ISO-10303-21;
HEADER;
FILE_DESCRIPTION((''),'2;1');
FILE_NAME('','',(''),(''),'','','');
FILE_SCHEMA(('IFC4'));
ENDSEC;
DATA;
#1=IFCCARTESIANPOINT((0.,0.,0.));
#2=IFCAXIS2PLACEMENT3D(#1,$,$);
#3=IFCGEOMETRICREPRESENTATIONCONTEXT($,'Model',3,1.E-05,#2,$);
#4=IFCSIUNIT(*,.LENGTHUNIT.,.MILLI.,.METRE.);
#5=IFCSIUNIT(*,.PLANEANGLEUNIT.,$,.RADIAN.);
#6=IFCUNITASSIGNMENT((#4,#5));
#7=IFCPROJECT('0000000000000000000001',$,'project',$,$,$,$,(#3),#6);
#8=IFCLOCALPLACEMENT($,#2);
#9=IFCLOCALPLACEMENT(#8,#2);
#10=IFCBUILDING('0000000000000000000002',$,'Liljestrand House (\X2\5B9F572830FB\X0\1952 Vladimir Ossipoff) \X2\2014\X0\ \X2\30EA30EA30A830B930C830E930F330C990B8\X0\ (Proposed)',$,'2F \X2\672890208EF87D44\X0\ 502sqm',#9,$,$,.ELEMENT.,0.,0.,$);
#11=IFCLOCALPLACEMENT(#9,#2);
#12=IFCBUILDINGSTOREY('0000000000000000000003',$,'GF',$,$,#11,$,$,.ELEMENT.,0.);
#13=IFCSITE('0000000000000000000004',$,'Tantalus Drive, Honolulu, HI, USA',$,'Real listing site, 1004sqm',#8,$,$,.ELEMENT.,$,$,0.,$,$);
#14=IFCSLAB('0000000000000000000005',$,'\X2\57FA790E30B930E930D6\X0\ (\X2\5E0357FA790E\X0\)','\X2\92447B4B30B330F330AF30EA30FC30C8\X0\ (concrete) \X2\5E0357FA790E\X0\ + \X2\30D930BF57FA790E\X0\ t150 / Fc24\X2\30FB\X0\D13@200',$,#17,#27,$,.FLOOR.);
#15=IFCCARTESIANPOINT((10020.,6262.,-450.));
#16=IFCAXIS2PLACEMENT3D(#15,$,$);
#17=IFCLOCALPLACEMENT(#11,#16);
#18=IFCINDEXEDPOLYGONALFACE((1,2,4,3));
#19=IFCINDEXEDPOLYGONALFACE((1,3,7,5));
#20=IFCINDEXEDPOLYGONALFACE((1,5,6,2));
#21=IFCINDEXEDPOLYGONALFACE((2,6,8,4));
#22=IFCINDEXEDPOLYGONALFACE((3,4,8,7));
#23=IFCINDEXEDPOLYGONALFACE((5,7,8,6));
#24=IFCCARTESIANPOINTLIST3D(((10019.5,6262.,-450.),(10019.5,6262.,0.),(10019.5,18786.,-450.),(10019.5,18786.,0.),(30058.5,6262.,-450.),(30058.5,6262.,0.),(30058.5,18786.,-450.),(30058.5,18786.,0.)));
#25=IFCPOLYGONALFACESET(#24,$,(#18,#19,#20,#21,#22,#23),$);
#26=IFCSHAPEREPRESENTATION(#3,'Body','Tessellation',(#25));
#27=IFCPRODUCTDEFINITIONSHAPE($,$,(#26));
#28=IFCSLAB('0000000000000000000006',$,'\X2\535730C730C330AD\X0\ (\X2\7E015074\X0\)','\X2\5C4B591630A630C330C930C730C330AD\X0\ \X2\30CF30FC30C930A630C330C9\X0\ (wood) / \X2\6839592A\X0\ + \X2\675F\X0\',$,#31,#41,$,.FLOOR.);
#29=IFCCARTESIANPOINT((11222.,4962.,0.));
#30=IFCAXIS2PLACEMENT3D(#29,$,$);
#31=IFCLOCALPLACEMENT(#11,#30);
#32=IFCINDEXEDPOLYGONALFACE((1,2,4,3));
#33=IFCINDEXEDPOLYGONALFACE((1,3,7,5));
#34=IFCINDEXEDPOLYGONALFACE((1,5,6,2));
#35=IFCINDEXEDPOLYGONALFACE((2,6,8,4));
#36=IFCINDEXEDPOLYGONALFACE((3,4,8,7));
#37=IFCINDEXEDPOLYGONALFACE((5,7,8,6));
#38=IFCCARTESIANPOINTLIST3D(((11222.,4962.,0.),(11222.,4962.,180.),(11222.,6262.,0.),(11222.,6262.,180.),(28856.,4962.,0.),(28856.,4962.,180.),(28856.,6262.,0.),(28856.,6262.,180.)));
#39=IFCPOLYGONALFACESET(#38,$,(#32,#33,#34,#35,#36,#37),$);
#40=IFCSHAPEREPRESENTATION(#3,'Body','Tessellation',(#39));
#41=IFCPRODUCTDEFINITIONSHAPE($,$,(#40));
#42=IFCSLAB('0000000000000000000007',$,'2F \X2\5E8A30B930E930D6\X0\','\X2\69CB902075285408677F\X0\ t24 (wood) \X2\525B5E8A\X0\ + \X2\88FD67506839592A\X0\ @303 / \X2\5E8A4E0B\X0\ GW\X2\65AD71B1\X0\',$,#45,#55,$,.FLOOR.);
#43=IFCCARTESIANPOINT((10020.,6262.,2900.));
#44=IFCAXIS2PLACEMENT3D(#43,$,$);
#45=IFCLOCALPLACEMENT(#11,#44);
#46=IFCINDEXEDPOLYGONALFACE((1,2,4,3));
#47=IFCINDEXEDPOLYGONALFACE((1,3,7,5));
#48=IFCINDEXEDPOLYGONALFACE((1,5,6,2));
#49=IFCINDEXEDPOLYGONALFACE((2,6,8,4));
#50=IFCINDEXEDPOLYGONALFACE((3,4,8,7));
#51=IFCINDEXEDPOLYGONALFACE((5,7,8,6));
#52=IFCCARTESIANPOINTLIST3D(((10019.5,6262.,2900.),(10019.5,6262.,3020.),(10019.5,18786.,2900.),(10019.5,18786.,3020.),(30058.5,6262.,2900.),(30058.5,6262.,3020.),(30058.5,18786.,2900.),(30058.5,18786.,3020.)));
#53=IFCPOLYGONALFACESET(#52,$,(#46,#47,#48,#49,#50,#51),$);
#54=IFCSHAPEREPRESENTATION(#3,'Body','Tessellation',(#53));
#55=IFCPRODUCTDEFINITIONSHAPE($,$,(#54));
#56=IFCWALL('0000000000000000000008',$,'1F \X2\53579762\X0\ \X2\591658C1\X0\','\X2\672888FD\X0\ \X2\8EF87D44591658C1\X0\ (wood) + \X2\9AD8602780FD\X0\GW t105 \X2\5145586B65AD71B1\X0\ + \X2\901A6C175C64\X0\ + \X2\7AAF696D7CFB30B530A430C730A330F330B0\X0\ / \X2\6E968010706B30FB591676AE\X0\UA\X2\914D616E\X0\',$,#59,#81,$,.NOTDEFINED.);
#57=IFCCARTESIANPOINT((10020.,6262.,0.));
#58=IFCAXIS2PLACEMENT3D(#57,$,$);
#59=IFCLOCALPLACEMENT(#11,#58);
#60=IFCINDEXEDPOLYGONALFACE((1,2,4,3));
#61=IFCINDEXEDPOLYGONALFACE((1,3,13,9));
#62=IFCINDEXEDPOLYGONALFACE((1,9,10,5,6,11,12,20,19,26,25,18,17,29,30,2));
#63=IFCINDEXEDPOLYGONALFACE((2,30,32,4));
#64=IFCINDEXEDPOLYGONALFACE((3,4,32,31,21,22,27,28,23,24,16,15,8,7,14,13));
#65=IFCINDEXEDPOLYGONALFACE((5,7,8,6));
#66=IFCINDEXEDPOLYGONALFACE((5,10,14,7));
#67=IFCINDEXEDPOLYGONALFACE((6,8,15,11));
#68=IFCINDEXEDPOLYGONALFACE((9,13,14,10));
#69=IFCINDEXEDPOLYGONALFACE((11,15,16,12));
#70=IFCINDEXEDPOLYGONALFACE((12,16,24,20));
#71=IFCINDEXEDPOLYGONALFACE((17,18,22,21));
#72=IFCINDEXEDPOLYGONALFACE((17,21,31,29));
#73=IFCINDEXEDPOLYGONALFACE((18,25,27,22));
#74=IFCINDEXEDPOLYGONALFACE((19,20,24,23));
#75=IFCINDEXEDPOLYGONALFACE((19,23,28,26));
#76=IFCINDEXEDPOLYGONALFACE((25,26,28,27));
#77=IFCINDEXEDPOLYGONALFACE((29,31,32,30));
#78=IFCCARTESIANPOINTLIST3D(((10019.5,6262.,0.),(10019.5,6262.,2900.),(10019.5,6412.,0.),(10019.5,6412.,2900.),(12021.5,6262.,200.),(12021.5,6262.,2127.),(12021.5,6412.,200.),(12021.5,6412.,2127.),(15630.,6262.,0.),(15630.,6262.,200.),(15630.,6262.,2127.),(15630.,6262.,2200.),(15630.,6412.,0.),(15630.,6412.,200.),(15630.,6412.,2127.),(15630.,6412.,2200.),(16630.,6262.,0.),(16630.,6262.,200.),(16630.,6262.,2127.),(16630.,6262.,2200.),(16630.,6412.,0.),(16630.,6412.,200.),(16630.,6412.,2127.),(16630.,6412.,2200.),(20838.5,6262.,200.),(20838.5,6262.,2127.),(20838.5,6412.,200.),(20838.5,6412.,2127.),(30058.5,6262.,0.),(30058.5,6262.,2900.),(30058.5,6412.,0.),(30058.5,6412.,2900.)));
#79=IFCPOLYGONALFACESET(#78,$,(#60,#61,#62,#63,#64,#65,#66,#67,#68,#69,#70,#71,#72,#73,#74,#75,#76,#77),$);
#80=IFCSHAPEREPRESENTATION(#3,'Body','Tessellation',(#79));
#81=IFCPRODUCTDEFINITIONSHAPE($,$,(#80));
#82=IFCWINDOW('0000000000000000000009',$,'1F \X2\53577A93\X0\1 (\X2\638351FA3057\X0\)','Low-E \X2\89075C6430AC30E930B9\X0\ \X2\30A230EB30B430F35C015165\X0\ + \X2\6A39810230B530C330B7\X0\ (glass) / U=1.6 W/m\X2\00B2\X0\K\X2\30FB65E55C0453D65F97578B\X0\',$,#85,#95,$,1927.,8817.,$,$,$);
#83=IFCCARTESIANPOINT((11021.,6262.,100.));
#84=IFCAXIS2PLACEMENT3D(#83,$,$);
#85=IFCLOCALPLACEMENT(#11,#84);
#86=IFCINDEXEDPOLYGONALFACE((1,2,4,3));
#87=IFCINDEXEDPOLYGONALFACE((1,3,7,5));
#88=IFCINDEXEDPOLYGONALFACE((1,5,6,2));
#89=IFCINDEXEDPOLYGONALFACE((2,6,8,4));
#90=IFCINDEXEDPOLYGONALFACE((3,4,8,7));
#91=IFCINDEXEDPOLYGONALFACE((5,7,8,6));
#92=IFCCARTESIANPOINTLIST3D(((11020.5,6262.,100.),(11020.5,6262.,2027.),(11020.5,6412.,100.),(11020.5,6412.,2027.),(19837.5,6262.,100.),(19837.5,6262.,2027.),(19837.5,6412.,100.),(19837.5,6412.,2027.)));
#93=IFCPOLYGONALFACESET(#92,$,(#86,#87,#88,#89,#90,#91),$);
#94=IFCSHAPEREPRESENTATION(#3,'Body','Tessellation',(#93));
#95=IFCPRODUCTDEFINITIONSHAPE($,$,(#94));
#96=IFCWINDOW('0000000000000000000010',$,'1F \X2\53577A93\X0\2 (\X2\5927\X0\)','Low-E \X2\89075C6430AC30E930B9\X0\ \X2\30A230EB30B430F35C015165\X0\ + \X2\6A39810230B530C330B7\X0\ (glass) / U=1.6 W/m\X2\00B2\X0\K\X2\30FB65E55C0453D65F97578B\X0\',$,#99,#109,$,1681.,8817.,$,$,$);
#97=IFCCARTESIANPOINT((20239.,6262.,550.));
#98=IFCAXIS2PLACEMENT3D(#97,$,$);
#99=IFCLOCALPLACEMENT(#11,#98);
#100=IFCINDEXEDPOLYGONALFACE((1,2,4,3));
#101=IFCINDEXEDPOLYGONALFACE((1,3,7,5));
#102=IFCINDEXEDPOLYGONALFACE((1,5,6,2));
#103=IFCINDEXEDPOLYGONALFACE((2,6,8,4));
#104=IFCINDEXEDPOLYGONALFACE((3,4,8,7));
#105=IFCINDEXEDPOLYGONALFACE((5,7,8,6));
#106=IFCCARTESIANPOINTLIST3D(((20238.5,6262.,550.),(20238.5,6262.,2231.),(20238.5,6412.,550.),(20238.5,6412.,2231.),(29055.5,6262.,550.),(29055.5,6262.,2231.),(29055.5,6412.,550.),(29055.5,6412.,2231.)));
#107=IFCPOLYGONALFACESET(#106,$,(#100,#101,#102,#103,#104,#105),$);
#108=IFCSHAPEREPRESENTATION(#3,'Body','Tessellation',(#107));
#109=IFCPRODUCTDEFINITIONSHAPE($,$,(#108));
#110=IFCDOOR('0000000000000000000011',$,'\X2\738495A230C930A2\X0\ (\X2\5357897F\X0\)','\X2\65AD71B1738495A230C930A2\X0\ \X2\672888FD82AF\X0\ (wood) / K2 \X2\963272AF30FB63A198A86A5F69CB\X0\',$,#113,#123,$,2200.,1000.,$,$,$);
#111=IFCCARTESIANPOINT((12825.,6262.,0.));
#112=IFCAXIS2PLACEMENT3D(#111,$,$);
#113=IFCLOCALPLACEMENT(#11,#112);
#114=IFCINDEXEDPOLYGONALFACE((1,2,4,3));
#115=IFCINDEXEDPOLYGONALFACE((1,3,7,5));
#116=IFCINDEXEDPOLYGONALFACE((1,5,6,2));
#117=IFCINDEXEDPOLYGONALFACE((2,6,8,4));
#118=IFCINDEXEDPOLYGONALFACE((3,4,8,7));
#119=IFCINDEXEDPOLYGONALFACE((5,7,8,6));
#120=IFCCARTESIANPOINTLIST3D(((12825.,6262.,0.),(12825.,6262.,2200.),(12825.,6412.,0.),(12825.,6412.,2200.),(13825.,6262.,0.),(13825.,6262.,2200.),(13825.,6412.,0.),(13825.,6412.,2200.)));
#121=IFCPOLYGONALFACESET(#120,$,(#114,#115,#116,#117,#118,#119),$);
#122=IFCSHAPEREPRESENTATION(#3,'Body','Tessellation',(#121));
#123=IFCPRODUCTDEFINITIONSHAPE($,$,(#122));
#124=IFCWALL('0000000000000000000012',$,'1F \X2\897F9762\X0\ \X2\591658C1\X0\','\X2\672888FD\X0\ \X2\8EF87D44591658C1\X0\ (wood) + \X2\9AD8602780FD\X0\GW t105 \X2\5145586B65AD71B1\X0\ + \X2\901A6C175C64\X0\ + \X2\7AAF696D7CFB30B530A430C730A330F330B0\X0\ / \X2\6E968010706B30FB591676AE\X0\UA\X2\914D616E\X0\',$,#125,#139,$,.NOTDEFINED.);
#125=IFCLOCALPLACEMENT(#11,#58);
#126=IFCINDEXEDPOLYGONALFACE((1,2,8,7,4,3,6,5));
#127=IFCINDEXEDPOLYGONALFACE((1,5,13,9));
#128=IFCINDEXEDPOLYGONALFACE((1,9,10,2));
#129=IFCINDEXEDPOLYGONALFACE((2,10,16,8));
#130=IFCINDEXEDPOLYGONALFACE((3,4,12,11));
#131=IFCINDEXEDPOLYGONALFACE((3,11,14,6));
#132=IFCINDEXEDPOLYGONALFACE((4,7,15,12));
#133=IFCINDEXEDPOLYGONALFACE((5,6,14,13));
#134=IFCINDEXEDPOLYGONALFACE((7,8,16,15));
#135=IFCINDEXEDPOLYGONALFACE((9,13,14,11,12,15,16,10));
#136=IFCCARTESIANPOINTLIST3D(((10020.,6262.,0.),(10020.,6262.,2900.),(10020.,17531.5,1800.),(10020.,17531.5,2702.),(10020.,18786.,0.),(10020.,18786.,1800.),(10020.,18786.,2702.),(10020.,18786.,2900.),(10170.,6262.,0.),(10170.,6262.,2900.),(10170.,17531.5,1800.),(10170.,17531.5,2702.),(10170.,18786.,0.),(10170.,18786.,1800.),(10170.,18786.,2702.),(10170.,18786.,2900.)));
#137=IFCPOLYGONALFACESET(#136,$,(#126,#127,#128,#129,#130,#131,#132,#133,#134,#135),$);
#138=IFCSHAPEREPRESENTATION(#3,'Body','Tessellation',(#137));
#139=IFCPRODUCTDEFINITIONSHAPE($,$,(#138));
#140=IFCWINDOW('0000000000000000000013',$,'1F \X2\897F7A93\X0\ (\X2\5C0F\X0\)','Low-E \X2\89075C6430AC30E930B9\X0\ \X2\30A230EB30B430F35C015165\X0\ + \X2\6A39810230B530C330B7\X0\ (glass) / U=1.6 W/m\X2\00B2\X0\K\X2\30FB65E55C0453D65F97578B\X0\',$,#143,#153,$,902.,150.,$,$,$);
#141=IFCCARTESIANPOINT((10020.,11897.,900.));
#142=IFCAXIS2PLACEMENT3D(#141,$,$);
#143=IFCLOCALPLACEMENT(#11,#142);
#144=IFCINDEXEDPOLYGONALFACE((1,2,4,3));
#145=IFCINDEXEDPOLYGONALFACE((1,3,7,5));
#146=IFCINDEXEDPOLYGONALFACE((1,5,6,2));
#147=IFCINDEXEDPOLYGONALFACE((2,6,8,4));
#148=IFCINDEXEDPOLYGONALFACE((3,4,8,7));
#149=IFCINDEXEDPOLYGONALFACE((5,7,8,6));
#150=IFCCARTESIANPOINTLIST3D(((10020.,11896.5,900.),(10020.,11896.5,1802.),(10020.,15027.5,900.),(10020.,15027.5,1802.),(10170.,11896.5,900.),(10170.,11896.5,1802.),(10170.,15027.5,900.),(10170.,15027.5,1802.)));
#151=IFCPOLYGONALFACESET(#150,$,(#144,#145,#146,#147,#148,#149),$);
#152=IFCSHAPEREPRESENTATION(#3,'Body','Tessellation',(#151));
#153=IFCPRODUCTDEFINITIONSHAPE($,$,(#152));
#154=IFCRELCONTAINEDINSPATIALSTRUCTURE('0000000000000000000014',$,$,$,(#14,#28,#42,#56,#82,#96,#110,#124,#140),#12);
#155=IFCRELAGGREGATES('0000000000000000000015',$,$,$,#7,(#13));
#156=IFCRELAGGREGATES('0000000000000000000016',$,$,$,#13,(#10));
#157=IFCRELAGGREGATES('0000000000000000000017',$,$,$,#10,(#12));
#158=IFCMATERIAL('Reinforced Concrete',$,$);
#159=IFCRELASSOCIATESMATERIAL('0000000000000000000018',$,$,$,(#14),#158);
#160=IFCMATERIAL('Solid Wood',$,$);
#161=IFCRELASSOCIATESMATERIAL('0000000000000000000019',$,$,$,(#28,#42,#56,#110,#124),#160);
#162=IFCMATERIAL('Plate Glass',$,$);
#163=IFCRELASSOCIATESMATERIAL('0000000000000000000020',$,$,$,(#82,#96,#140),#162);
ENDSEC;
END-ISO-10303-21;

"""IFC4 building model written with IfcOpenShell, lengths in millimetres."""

from ifc_helpers import new_model, si_unit, frame, frame_2d, origin, place, context, project, spatial, rectangle, extrude, material, element, fill, save


model = new_model("IFC4")

# Units and contexts
model_context = context("Model", 3, precision=1e-05, world=origin())
ifc_project = project(units=[si_unit("LENGTHUNIT", "METRE", prefix="MILLI"), si_unit("PLANEANGLEUNIT", "RADIAN")], contexts=[model_context])

# Site, building, storey
site_placement = place(None, origin())
site = spatial("IfcSite", under=ifc_project, at=site_placement, Name="Tantalus Drive, Honolulu, HI, USA", ObjectType="Real listing site, 1004sqm", CompositionType="ELEMENT", RefElevation=0.0)
building_placement = place(site_placement, origin())
building = spatial("IfcBuilding", under=site, at=building_placement, Name="Liljestrand House (実在・1952 Vladimir Ossipoff) — リリエストランド邸 (Proposed)", ObjectType="2F 木造軸組 502sqm", CompositionType="ELEMENT", ElevationOfRefHeight=0.0, ElevationOfTerrain=0.0)
storey_placement = place(building_placement, origin())
storey = spatial("IfcBuildingStorey", under=building, at=storey_placement, Name="GF", CompositionType="ELEMENT", Elevation=0.0)

# Slabs
ifc_material_1 = material(Name="Reinforced Concrete")
slab_1_placement = place(storey_placement, frame((10020.0, 6262.0, -450.0)))
element("IfcSlab", 1, at=slab_1_placement, inside=storey, material=ifc_material_1, Name="基礎スラブ (布基礎)", Description="鉄筋コンクリート (concrete) 布基礎 + ベタ基礎 t150 / Fc24・D13@200", PredefinedType="FLOOR", context=model_context, shape_type="SweptSolid", body=[
    extrude(rectangle(XDim=20039.0, YDim=12524.0, at=frame_2d((10019.0, 6262.0))), frame((10020.0, 6262.0, -450.0)), (0.0, 0.0, 1.0), 450.0),
])
ifc_material_2 = material(Name="Solid Wood")
slab_2_placement = place(storey_placement, frame((11222.0, 4962.0, 0.0)))
element("IfcSlab", 2, at=slab_2_placement, inside=storey, material=ifc_material_2, Name="南デッキ (縁側)", Description="屋外ウッドデッキ ハードウッド (wood) / 根太 + 束", PredefinedType="FLOOR", context=model_context, shape_type="SweptSolid", body=[
    extrude(rectangle(XDim=17634.0, YDim=1300.0, at=frame_2d((8817.0, 650.0))), frame((11222.0, 4962.0, 0.0)), (0.0, 0.0, 1.0), 180.0),
])
slab_3_placement = place(storey_placement, frame((10020.0, 6262.0, 2900.0)))
element("IfcSlab", 3, at=slab_3_placement, inside=storey, material=ifc_material_2, Name="2F 床スラブ", Description="構造用合板 t24 (wood) 剛床 + 製材根太 @303 / 床下 GW断熱", PredefinedType="FLOOR", context=model_context, shape_type="SweptSolid", body=[
    extrude(rectangle(XDim=20039.0, YDim=12524.0, at=frame_2d((10019.0, 6262.0))), frame((10020.0, 6262.0, 2900.0)), (0.0, 0.0, 1.0), 120.0),
])

# Wall, openings, windows, door
wall_1_placement = place(storey_placement, frame((10020.0, 6262.0, 0.0)))
wall_1 = element("IfcWall", 4, at=wall_1_placement, inside=storey, material=ifc_material_2, Name="1F 南面 外壁", Description="木製 軸組外壁 (wood) + 高性能GW t105 充填断熱 + 通気層 + 窯業系サイディング / 準耐火・外皮UA配慮", PredefinedType="NOTDEFINED", context=model_context, shape_type="SweptSolid", body=[
    extrude(rectangle(XDim=20039.0, YDim=150.0, at=frame_2d((10019.0, 75.0))), frame((10020.0, 6262.0, 0.0)), (0.0, 0.0, 1.0), 2900.0),
])
opening_1_placement = place(storey_placement, frame((11021.0, 6262.0, 100.0)))
opening_1 = element("IfcOpeningElement", 5, at=opening_1_placement, cuts=wall_1, PredefinedType="NOTDEFINED", context=model_context, shape_type="SweptSolid", body=[
    extrude(rectangle(XDim=8817.0, YDim=150.0, at=frame_2d((4408.0, 75.0))), frame((11021.0, 6262.0, 100.0)), (0.0, 0.0, 1.0), 1927.0),
])
opening_2_placement = place(storey_placement, frame((20239.0, 6262.0, 550.0)))
opening_2 = element("IfcOpeningElement", 6, at=opening_2_placement, cuts=wall_1, PredefinedType="NOTDEFINED", context=model_context, shape_type="SweptSolid", body=[
    extrude(rectangle(XDim=8817.0, YDim=150.0, at=frame_2d((4408.0, 75.0))), frame((20239.0, 6262.0, 550.0)), (0.0, 0.0, 1.0), 1681.0),
])
opening_3_placement = place(storey_placement, frame((12825.0, 6262.0, 0.0)))
opening_3 = element("IfcOpeningElement", 7, at=opening_3_placement, cuts=wall_1, PredefinedType="NOTDEFINED", context=model_context, shape_type="SweptSolid", body=[
    extrude(rectangle(XDim=1000.0, YDim=150.0, at=frame_2d((500.0, 75.0))), frame((12825.0, 6262.0, 0.0)), (0.0, 0.0, 1.0), 2200.0),
])
ifc_material_3 = material(Name="Plate Glass")
window_1_placement = place(storey_placement, frame((11021.0, 6262.0, 100.0)))
window_1 = element("IfcWindow", 8, at=window_1_placement, inside=storey, material=ifc_material_3, Name="1F 南窓1 (掃出し)", Description="Low-E 複層ガラス アルゴン封入 + 樹脂サッシ (glass) / U=1.6 W/m²K・日射取得型", OverallHeight=1927.0, OverallWidth=8817.0, context=model_context, shape_type="SweptSolid", body=[
    extrude(rectangle(XDim=8817.0, YDim=150.0, at=frame_2d((4408.0, 75.0))), frame((11021.0, 6262.0, 100.0)), (0.0, 0.0, 1.0), 1927.0),
])
fill(opening_1, window_1)
window_2_placement = place(storey_placement, frame((20239.0, 6262.0, 550.0)))
window_2 = element("IfcWindow", 9, at=window_2_placement, inside=storey, material=ifc_material_3, Name="1F 南窓2 (大)", Description="Low-E 複層ガラス アルゴン封入 + 樹脂サッシ (glass) / U=1.6 W/m²K・日射取得型", OverallHeight=1681.0, OverallWidth=8817.0, context=model_context, shape_type="SweptSolid", body=[
    extrude(rectangle(XDim=8817.0, YDim=150.0, at=frame_2d((4408.0, 75.0))), frame((20239.0, 6262.0, 550.0)), (0.0, 0.0, 1.0), 1681.0),
])
fill(opening_2, window_2)
door_placement = place(storey_placement, frame((12825.0, 6262.0, 0.0)))
door = element("IfcDoor", 10, at=door_placement, inside=storey, material=ifc_material_2, Name="玄関ドア (南西)", Description="断熱玄関ドア 木製芯 (wood) / K2 防犯・採風機構", OverallHeight=2200.0, OverallWidth=1000.0, context=model_context, shape_type="SweptSolid", body=[
    extrude(rectangle(XDim=1000.0, YDim=150.0, at=frame_2d((500.0, 75.0))), frame((12825.0, 6262.0, 0.0)), (0.0, 0.0, 1.0), 2200.0),
])
fill(opening_3, door)

# Wall, opening, window
wall_2_placement = place(storey_placement, frame((10020.0, 6262.0, 0.0)))
wall_2 = element("IfcWall", 11, at=wall_2_placement, inside=storey, material=ifc_material_2, Name="1F 西面 外壁", Description="木製 軸組外壁 (wood) + 高性能GW t105 充填断熱 + 通気層 + 窯業系サイディング / 準耐火・外皮UA配慮", PredefinedType="NOTDEFINED", context=model_context, shape_type="SweptSolid", body=[
    extrude(rectangle(XDim=150.0, YDim=12524.0, at=frame_2d((75.0, 6262.0))), frame((10020.0, 6262.0, 0.0)), (0.0, 0.0, 1.0), 2900.0),
])
opening_4_placement = place(storey_placement, frame((10020.0, 11897.0, 900.0)))
opening_4 = element("IfcOpeningElement", 12, at=opening_4_placement, cuts=wall_2, PredefinedType="NOTDEFINED", context=model_context, shape_type="SweptSolid", body=[
    extrude(rectangle(XDim=150.0, YDim=3131.0, at=frame_2d((75.0, 1565.0))), frame((10020.0, 11897.0, 900.0)), (0.0, 0.0, 1.0), 902.0),
])
window_3_placement = place(storey_placement, frame((10020.0, 11897.0, 900.0)))
window_3 = element("IfcWindow", 13, at=window_3_placement, inside=storey, material=ifc_material_3, Name="1F 西窓 (小)", Description="Low-E 複層ガラス アルゴン封入 + 樹脂サッシ (glass) / U=1.6 W/m²K・日射取得型", OverallHeight=902.0, OverallWidth=150.0, context=model_context, shape_type="SweptSolid", body=[
    extrude(rectangle(XDim=150.0, YDim=3131.0, at=frame_2d((75.0, 1565.0))), frame((10020.0, 11897.0, 900.0)), (0.0, 0.0, 1.0), 902.0),
])
fill(opening_4, window_3)

save(model, "model.ifc")
